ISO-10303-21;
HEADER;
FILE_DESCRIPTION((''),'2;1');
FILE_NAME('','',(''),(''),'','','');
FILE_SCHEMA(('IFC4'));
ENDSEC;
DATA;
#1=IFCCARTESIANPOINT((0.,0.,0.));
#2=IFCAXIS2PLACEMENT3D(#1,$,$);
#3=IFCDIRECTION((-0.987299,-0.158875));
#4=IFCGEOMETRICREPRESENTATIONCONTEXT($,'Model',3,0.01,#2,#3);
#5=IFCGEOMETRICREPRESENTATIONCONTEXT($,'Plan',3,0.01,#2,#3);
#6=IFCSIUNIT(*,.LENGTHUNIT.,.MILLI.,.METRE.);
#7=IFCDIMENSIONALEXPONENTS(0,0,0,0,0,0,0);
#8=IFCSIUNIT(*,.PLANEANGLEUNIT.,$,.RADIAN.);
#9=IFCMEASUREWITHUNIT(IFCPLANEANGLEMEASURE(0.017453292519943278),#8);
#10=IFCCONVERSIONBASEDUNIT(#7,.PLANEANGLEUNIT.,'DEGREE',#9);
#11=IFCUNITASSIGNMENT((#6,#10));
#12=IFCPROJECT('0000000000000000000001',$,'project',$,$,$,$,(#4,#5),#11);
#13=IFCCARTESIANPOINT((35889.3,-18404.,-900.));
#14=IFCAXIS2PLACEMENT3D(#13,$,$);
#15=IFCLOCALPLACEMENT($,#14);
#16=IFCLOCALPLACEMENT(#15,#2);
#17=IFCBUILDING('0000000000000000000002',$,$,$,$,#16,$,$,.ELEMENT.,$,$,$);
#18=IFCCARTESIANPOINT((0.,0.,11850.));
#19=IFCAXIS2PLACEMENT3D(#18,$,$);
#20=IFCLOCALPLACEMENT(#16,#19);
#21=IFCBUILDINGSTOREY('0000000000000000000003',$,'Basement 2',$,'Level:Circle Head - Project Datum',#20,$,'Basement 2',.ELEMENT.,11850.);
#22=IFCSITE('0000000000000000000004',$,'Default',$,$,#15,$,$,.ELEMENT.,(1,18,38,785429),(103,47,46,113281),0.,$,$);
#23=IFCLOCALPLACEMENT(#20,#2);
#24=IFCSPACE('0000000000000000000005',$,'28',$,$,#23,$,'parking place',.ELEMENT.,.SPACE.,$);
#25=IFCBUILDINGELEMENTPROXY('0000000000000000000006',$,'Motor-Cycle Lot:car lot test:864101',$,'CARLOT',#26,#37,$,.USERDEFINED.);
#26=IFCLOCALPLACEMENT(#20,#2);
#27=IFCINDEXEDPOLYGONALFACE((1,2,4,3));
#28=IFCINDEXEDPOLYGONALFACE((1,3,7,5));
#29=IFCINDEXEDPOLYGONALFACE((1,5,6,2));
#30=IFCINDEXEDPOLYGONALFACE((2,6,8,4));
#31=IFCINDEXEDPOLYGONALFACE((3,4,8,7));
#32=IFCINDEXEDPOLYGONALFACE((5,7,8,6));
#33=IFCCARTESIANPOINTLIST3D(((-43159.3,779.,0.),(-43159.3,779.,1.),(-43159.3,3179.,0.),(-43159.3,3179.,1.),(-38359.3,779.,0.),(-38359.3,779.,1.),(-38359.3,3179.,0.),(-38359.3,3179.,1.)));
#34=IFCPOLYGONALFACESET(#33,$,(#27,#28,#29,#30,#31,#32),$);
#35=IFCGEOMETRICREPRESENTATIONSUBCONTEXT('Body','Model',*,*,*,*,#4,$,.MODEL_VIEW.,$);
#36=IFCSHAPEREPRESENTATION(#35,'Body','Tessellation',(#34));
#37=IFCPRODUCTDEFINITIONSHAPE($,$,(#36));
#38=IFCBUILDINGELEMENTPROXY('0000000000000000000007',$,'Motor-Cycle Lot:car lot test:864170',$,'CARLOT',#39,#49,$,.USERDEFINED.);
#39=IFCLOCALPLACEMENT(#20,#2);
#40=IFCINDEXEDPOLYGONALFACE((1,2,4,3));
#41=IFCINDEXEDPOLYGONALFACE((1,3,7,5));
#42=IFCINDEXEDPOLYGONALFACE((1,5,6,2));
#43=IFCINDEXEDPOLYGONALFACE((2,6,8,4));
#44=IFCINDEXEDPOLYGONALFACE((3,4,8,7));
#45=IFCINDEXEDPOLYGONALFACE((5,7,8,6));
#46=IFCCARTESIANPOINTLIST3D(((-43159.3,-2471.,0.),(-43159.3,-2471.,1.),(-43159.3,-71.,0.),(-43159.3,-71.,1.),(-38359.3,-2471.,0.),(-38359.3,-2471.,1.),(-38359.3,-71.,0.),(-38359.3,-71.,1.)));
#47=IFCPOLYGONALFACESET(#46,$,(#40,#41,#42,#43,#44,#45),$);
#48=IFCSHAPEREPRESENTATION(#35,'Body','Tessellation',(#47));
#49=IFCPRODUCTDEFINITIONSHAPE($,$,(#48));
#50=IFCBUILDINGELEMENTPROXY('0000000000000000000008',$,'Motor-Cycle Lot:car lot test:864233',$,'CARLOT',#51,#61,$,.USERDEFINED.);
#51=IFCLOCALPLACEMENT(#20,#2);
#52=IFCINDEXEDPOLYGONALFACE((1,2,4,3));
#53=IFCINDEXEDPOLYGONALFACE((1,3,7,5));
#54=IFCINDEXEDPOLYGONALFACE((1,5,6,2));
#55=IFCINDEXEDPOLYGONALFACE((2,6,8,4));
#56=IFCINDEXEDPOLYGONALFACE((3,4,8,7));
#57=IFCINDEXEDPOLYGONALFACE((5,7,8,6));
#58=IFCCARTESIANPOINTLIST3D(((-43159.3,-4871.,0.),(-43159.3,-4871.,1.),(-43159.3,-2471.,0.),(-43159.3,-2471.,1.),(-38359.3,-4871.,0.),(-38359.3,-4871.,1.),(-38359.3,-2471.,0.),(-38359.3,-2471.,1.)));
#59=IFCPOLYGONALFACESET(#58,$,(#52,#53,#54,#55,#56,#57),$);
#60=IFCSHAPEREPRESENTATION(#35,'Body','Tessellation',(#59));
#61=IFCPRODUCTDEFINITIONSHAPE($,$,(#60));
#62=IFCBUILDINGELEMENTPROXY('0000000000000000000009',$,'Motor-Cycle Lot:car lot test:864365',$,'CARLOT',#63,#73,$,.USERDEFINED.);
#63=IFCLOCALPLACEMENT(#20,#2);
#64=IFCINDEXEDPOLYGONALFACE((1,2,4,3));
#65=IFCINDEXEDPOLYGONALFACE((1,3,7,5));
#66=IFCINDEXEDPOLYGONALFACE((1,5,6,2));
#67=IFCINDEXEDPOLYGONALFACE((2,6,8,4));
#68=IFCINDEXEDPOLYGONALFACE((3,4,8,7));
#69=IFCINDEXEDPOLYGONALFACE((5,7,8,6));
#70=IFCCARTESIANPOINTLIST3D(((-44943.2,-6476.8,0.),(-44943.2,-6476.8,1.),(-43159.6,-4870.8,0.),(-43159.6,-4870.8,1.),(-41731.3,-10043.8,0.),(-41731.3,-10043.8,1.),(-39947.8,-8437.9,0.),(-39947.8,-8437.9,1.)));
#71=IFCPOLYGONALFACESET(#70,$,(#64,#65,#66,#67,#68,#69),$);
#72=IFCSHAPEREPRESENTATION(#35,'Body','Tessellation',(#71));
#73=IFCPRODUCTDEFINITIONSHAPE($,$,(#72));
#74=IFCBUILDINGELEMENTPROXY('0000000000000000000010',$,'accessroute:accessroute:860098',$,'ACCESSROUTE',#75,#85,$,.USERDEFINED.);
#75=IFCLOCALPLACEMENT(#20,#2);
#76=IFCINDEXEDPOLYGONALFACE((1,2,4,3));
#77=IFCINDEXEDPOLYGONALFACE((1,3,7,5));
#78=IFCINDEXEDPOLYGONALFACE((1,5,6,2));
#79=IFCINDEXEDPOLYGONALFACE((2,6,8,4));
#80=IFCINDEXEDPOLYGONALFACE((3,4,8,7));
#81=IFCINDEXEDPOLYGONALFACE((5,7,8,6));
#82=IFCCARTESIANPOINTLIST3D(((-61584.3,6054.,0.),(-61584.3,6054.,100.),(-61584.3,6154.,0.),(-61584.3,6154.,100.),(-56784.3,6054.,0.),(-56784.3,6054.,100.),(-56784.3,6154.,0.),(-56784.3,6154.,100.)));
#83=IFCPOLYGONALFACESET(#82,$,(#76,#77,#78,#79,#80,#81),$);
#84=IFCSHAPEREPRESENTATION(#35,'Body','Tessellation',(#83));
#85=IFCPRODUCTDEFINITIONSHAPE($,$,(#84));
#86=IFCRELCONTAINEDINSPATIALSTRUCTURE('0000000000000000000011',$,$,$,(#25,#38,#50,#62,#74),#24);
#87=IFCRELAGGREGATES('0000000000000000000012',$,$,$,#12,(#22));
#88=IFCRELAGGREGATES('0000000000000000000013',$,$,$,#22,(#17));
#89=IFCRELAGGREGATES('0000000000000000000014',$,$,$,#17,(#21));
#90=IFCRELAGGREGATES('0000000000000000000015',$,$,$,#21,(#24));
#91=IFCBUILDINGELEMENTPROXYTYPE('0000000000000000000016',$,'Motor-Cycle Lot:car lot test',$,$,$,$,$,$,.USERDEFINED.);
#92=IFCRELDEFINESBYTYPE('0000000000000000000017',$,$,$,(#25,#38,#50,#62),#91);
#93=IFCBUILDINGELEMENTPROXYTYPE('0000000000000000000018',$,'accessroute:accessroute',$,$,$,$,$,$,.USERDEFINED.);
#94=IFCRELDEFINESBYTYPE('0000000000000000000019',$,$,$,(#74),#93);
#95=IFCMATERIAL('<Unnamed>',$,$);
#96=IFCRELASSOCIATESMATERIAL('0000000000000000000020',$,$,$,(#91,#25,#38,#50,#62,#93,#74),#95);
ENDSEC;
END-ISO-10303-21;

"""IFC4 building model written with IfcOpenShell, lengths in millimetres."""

from ifc_helpers import new_model, entity, si_unit, converted_unit, direction, frame, origin, place, context, subcontext, project, spatial, indexed_curve, outline, extrude, source, transform, mapped, material, type_object, type_shapes, element, save


model = new_model("IFC4")

# Units and contexts
model_context = context("Model", 3, precision=0.01, world=origin(), true_north=direction((-0.987299, -0.158875)))
plan_context = context("Plan", 3, precision=0.01, world=origin(), true_north=direction((-0.987299, -0.158875)))
body_context = subcontext(model_context, "Body", "Model", "MODEL_VIEW")
ifc_project = project(units=[si_unit("LENGTHUNIT", "METRE", prefix="MILLI"), converted_unit("PLANEANGLEUNIT", "DEGREE", entity("IfcPlaneAngleMeasure", 0.017453292519943278), si_unit("PLANEANGLEUNIT", "RADIAN"), dimensions=[0, 0, 0, 0, 0, 0, 0])], contexts=[model_context, plan_context])

# Site, building, storey
site_placement = place(None, frame((35889.3, -18404.0, -900.0)))
site = spatial("IfcSite", under=ifc_project, at=site_placement, Name="Default", CompositionType="ELEMENT", RefLatitude=(1, 18, 38, 785429), RefLongitude=(103, 47, 46, 113281), RefElevation=0.0)
building_placement = place(site_placement, origin())
building = spatial("IfcBuilding", under=site, at=building_placement, CompositionType="ELEMENT")
storey_placement = place(building_placement, frame((0.0, 0.0, 11850.0)))
storey = spatial("IfcBuildingStorey", under=building, at=storey_placement, Name="Basement 2", ObjectType="Level:Circle Head - Project Datum", LongName="Basement 2", CompositionType="ELEMENT", Elevation=11850.0)

# Shared definitions
ifc_material_1 = material(Name="<Unnamed>")

# Shared definitions
space_placement = place(storey_placement, origin())
space = spatial("IfcSpace", under=storey, at=space_placement, Name="28", LongName="parking place", CompositionType="ELEMENT", PredefinedType="SPACE")

# Building element proxies
building_element_proxy_type_1 = type_object("IfcBuildingElementProxyType", Name="Motor-Cycle Lot:car lot test", PredefinedType="USERDEFINED", material=ifc_material_1)
shared_shape_1 = source(origin(), body_context, "Body", "SweptSolid", [
    extrude(outline(indexed_curve([(-2400.0, -1200.0), (2400.0, -1200.0), (2400.0, 1200.0), (-2400.0, 1200.0), (-2400.0, -1200.0)], self_intersect=False)), frame((0.0, 0.0, 0.0), z_axis=(0.0, 0.0, 1.0), x_axis=(-1.0, 0.0, 0.0)), (0.0, 0.0, 1.0), 1.0),
])
type_shapes(building_element_proxy_type_1, [shared_shape_1])
for number, where, name in (
    (1, (-40759.3, 1979.0, 0.0), "Motor-Cycle Lot:car lot test:864101"),
    (2, (-40759.3, -1271.0, 0.0), "Motor-Cycle Lot:car lot test:864170"),
    (3, (-40759.3, -3671.0, 0.0), "Motor-Cycle Lot:car lot test:864233"),
):
    element("IfcBuildingElementProxy", number, at=place(space_placement, frame(where)), inside=space, type_object=building_element_proxy_type_1, material=ifc_material_1, Name=name, ObjectType="CARLOT", PredefinedType="USERDEFINED", context=body_context, shape_type="MappedRepresentation", body=[
        mapped(shared_shape_1, transform((0.0, 0.0, 0.0), scale=1.0)),
    ])
proxy_1_placement = place(space_placement, frame((-42445.5, -7457.3, 0.0), z_axis=(0.0, 0.0, 1.0), x_axis=(0.669131, -0.743145, 0.0)))
element("IfcBuildingElementProxy", 4, at=proxy_1_placement, inside=space, type_object=building_element_proxy_type_1, material=ifc_material_1, Name="Motor-Cycle Lot:car lot test:864365", ObjectType="CARLOT", PredefinedType="USERDEFINED", context=body_context, shape_type="MappedRepresentation", body=[
    mapped(shared_shape_1, transform((0.0, 0.0, 0.0), scale=1.0)),
])
building_element_proxy_type_2 = type_object("IfcBuildingElementProxyType", Name="accessroute:accessroute", PredefinedType="USERDEFINED", material=ifc_material_1)
shared_shape_2 = source(origin(), body_context, "Body", "SweptSolid", [
    extrude(outline(indexed_curve([(-2400.0, -50.0), (2400.0, -50.0), (2400.0, 50.0), (-2400.0, 50.0), (-2400.0, -50.0)], self_intersect=False)), frame((-59184.3, 6104.0, 11850.0), z_axis=(0.0, 0.0, 1.0), x_axis=(-1.0, 0.0, 0.0)), (0.0, 0.0, 1.0), 100.0),
])
type_shapes(building_element_proxy_type_2, [shared_shape_2])
proxy_2_placement = place(space_placement, frame((0.0, 0.0, -11850.0)))
element("IfcBuildingElementProxy", 5, at=proxy_2_placement, inside=space, type_object=building_element_proxy_type_2, material=ifc_material_1, Name="accessroute:accessroute:860098", ObjectType="ACCESSROUTE", PredefinedType="USERDEFINED", context=body_context, shape_type="MappedRepresentation", body=[
    mapped(shared_shape_2, transform((0.0, 0.0, 0.0), scale=1.0)),
])

save(model, "model.ifc")
